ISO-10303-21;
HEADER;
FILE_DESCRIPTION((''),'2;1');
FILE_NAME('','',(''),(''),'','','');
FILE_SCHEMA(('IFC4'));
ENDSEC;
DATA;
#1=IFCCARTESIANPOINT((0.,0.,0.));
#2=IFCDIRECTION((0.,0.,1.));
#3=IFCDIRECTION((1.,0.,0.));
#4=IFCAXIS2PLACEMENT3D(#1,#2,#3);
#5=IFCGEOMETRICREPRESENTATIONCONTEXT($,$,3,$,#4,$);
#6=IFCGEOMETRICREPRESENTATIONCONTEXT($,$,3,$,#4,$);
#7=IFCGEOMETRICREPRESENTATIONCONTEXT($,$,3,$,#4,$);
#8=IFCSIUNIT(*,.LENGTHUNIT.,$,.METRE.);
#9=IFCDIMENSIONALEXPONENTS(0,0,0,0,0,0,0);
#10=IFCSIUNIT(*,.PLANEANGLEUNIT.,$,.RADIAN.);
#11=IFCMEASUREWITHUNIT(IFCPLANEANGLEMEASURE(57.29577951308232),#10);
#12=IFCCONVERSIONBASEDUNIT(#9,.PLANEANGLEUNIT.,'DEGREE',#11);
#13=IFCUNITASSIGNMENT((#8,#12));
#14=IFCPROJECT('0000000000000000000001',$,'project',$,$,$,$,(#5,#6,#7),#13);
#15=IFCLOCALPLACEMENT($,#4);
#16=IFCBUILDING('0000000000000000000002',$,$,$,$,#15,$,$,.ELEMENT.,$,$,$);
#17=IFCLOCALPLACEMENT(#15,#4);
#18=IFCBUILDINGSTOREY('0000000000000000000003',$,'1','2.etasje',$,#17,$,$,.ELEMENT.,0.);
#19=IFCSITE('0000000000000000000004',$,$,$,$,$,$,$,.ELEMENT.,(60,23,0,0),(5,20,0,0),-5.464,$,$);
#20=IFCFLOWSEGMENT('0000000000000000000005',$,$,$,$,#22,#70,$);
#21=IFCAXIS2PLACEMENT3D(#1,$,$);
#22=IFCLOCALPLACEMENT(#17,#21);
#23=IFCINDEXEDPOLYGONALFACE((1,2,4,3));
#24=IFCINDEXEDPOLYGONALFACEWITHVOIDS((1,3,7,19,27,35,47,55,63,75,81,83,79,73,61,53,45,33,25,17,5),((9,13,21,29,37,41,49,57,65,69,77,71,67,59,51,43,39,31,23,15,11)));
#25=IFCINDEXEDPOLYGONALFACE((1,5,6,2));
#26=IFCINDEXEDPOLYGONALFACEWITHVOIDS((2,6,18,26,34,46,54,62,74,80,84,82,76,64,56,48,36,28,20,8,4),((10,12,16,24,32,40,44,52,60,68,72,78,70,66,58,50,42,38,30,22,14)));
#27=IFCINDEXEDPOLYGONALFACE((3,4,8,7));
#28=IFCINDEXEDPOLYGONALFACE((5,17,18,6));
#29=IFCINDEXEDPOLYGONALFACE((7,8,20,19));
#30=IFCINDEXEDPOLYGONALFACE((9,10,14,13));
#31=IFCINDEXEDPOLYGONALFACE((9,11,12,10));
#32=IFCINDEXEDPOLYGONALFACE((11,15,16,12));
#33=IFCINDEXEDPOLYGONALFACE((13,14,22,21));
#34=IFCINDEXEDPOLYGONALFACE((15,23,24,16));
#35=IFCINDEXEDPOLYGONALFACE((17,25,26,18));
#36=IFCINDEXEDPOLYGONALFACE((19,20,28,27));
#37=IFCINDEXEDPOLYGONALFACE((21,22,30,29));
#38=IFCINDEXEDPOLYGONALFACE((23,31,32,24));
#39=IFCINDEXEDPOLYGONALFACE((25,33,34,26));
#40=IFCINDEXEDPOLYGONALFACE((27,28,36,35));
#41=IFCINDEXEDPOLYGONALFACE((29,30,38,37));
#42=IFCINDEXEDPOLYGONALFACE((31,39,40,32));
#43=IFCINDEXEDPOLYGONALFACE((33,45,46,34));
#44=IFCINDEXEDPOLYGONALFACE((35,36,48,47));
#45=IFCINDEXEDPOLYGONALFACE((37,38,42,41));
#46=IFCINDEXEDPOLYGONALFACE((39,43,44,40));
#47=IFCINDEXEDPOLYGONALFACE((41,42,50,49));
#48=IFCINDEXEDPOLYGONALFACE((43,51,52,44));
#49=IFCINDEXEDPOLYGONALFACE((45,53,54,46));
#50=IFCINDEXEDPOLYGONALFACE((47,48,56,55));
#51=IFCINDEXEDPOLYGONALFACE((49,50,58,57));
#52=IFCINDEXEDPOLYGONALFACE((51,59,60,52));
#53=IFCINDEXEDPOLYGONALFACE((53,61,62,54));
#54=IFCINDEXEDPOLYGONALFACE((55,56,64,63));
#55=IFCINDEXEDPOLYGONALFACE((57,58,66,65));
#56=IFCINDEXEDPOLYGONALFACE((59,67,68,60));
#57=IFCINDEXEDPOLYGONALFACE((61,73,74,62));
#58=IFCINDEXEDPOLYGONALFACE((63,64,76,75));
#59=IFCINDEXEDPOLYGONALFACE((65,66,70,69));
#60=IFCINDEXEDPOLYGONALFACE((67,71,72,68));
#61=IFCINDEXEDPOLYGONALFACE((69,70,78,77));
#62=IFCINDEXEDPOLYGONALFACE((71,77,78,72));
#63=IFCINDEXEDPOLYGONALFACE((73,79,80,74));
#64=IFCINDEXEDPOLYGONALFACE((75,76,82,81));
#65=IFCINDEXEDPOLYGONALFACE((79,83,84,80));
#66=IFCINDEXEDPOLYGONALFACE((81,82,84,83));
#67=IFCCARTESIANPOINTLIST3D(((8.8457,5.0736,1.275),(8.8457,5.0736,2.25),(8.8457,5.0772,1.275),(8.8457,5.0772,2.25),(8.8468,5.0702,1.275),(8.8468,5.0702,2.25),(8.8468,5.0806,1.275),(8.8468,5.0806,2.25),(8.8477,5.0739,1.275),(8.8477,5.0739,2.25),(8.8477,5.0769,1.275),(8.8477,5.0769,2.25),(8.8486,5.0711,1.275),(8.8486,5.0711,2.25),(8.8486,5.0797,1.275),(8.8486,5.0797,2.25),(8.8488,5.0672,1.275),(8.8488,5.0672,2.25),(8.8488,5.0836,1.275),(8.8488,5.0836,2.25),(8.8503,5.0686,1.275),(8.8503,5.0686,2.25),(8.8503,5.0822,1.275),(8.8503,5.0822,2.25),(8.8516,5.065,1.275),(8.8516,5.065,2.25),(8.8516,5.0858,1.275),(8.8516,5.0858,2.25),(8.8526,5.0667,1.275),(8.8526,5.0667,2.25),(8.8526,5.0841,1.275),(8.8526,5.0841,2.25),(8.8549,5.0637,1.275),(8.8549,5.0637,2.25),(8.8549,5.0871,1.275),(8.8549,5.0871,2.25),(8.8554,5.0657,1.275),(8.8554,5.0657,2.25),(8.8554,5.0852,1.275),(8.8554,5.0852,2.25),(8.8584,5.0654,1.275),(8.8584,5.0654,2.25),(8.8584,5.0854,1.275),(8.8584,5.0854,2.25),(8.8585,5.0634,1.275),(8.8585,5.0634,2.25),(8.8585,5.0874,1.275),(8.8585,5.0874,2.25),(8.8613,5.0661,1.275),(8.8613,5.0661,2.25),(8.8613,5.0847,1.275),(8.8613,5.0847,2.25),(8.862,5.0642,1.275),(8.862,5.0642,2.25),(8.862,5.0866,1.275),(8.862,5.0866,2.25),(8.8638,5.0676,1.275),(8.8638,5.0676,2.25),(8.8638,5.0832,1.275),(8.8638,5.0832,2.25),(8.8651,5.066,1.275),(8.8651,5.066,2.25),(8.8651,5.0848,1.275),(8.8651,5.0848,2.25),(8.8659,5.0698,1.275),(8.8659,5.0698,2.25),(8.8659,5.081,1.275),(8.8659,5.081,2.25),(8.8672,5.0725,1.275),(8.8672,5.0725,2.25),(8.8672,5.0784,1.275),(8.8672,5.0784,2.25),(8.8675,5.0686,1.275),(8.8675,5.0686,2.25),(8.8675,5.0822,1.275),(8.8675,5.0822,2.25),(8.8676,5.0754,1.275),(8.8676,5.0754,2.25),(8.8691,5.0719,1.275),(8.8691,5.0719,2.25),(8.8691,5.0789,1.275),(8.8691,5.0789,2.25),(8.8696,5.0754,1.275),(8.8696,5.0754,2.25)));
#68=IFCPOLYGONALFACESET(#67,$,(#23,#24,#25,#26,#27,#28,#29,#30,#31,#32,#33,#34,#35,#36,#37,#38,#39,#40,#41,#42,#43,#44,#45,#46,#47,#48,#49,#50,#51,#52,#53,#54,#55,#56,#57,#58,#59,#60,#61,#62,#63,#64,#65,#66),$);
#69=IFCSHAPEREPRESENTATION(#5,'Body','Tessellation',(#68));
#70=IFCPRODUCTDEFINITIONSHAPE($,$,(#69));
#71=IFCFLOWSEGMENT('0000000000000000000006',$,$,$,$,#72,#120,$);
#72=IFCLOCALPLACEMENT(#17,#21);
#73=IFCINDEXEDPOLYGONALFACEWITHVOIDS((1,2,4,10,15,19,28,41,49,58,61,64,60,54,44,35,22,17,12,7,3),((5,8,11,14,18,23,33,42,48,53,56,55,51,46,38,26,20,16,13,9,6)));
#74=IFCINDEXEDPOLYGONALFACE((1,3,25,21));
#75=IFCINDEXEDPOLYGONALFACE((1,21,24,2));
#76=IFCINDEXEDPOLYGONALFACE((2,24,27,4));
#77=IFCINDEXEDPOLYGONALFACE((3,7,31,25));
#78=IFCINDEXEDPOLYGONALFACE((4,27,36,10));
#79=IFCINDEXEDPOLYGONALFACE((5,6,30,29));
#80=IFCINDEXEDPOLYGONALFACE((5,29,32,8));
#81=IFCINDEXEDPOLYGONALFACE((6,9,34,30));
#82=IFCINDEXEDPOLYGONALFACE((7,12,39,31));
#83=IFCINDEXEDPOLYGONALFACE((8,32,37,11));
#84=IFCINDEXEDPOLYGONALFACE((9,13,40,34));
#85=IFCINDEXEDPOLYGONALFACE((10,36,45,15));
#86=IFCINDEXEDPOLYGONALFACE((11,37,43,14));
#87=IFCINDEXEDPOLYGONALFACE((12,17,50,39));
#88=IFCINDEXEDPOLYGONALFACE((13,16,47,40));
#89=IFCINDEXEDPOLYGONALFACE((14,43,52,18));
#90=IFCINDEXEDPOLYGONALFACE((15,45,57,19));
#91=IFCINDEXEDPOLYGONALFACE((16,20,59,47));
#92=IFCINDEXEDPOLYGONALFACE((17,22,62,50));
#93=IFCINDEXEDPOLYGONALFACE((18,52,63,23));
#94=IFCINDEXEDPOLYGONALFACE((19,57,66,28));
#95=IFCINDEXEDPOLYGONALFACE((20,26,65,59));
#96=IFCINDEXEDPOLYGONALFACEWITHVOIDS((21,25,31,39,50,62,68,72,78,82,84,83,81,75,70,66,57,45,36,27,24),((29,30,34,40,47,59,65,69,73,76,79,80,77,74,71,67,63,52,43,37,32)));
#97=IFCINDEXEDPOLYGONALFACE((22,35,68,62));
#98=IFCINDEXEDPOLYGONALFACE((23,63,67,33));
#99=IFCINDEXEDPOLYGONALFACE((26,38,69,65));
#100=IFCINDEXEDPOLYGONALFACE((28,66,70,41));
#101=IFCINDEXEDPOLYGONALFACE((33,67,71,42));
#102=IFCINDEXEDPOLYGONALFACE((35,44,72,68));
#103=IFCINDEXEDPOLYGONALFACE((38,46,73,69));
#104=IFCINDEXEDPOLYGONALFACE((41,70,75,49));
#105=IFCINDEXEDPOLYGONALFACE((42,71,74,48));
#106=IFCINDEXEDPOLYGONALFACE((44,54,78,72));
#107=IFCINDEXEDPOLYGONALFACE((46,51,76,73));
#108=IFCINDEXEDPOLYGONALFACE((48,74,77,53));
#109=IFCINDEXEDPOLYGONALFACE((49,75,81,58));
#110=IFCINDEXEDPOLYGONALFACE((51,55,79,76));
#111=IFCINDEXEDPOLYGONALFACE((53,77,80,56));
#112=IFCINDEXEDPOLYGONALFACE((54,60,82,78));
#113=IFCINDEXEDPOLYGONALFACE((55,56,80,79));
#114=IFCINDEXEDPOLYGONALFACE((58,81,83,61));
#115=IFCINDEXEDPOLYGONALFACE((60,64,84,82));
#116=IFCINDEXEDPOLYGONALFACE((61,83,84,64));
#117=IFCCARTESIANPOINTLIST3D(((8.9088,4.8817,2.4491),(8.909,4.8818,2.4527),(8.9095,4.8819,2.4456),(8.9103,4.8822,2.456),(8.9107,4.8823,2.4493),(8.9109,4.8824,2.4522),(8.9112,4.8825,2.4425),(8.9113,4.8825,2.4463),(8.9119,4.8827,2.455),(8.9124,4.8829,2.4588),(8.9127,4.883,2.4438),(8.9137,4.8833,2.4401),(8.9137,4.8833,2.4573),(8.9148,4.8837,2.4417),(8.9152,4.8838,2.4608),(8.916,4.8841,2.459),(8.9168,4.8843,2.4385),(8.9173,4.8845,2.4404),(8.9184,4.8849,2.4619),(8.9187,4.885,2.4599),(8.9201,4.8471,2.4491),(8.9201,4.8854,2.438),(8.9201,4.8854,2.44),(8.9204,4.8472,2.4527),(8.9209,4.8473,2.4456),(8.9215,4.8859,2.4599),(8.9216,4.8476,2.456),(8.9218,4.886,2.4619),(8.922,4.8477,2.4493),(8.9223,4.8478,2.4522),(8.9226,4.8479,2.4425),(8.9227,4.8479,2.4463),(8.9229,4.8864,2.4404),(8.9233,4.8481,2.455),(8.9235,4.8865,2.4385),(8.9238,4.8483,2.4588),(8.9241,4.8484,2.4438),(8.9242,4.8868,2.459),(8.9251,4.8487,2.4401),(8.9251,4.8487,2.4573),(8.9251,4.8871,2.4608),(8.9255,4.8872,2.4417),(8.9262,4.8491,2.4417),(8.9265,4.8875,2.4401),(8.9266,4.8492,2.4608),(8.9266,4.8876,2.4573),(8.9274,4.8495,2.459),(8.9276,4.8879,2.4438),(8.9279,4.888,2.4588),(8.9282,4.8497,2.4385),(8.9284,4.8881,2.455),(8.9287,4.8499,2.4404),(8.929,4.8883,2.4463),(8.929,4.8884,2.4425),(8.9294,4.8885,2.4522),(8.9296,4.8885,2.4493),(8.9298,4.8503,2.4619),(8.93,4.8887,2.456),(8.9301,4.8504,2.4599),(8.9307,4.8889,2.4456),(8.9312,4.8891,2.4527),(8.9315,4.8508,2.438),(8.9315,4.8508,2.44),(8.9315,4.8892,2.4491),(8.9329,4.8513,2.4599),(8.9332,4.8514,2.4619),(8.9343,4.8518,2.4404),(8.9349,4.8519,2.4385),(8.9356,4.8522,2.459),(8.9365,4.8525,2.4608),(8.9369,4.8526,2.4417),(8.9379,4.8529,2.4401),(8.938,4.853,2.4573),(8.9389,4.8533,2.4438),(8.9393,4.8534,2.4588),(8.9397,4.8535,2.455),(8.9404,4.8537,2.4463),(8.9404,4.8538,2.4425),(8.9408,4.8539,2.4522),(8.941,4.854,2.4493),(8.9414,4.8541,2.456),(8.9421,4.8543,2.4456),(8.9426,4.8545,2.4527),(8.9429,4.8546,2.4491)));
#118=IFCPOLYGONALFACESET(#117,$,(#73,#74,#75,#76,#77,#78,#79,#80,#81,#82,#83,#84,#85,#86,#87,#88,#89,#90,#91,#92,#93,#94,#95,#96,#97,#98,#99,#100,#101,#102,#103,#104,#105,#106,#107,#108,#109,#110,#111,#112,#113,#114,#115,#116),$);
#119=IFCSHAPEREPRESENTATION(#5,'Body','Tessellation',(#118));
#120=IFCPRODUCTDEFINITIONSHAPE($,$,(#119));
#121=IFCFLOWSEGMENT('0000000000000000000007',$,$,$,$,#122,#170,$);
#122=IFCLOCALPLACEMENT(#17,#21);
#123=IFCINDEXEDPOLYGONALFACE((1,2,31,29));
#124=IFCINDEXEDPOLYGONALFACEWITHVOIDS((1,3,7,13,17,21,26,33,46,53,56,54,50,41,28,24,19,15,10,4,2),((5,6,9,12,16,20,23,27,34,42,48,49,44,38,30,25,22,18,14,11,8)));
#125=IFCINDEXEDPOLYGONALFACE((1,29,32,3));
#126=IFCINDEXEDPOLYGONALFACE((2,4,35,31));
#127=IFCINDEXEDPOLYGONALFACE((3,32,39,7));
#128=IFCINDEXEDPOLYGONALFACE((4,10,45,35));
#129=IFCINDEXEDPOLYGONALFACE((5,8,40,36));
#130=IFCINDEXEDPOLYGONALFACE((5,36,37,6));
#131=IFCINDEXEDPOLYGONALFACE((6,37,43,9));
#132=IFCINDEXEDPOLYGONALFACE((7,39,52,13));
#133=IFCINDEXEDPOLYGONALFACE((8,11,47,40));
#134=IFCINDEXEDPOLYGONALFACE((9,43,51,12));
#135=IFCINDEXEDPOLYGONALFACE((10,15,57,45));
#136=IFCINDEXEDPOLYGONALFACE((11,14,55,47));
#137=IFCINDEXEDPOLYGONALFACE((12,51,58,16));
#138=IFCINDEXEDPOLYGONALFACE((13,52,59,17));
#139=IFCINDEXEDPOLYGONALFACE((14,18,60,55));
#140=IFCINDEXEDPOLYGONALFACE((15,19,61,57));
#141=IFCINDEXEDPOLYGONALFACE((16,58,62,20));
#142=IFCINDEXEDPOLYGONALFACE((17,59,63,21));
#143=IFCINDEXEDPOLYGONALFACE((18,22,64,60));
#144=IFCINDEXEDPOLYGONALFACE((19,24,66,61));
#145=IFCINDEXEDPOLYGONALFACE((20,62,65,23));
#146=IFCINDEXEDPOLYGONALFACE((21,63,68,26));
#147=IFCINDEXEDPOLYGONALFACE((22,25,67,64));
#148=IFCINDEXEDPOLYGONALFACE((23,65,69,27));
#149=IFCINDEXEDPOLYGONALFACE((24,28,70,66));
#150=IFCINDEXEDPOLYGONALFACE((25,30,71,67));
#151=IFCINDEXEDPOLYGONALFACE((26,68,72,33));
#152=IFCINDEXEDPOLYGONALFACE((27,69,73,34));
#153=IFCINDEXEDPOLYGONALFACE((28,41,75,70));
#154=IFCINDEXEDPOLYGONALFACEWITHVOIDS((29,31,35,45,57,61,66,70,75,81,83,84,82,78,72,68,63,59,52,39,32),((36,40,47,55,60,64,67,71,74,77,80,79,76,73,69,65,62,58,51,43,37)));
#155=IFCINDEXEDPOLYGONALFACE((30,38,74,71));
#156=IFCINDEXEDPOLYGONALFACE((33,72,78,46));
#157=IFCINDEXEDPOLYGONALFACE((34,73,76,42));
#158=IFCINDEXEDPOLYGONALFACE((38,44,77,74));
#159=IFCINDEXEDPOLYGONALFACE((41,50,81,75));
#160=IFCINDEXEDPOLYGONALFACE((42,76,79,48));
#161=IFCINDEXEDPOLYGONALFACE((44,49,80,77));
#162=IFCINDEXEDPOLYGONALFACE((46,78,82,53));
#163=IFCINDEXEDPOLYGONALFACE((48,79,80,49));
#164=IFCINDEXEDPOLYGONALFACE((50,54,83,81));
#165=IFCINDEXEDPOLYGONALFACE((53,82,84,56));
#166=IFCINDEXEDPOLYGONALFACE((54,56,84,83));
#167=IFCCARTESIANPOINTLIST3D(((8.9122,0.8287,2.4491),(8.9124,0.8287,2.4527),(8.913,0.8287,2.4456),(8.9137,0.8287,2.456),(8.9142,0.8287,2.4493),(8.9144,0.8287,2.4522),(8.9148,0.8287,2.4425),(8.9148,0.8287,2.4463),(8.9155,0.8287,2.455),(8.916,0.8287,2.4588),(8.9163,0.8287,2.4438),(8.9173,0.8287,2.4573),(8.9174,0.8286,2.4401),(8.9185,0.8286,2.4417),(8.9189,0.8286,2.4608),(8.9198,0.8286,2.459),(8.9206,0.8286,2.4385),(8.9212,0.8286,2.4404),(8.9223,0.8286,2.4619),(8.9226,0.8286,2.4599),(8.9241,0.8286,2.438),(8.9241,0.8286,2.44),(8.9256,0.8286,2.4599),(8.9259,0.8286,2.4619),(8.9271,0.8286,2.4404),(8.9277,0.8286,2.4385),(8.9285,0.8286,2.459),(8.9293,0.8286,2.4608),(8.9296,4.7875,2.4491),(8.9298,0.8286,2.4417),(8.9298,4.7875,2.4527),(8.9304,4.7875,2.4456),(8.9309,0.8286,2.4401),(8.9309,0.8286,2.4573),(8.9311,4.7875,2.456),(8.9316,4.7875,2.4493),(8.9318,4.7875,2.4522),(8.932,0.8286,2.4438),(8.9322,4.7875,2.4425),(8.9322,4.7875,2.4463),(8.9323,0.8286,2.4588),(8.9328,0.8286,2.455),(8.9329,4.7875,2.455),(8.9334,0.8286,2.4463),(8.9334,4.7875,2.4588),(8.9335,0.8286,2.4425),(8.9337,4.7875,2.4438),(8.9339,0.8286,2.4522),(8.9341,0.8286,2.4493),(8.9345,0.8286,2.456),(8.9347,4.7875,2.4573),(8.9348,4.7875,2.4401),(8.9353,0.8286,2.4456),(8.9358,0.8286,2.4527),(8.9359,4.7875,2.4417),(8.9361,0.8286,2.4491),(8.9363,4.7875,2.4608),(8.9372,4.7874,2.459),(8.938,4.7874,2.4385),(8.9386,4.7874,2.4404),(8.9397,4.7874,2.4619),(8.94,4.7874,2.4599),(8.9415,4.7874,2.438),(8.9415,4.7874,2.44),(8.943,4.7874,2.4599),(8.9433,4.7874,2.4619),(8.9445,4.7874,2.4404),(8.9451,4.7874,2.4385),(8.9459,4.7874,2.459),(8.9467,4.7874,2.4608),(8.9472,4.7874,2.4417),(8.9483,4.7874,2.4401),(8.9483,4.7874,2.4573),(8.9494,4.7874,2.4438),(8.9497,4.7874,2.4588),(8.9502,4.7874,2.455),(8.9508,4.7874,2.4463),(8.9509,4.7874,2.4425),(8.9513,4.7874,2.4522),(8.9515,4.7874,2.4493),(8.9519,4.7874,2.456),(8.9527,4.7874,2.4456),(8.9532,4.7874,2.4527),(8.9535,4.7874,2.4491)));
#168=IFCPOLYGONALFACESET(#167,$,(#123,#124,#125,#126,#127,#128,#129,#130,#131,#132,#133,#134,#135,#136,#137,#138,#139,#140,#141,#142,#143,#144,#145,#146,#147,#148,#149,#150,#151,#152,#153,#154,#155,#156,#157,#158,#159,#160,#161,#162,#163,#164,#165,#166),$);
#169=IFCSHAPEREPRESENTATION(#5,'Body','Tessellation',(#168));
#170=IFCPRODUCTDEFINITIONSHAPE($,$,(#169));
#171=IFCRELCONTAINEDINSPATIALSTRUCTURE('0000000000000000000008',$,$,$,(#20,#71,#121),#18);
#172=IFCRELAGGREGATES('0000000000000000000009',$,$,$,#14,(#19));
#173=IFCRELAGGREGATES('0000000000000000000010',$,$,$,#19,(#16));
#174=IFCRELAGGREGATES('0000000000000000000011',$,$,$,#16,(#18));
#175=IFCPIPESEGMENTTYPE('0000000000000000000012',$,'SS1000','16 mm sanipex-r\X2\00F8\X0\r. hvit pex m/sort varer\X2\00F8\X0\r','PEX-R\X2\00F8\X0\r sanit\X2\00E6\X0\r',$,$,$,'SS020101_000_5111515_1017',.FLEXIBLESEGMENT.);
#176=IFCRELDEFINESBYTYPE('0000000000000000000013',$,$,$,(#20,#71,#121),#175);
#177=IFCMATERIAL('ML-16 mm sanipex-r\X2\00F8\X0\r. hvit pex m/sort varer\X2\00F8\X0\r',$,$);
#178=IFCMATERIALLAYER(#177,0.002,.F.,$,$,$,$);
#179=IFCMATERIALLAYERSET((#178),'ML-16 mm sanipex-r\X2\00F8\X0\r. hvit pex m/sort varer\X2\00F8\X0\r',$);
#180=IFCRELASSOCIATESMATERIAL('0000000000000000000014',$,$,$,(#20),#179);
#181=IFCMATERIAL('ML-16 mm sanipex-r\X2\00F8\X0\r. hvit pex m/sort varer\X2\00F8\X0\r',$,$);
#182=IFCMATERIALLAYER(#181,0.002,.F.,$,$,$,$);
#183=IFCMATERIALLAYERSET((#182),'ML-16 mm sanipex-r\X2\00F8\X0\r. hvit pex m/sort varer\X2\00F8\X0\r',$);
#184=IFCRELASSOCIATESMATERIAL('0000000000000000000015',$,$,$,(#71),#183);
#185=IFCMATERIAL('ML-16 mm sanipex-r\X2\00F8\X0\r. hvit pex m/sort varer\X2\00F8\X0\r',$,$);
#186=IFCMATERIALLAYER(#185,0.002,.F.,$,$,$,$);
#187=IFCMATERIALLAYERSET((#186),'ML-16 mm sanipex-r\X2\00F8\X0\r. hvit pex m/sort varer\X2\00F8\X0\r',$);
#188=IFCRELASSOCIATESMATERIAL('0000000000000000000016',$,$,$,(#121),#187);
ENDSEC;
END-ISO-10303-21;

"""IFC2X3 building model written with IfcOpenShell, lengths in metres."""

from ifc_helpers import new_model, entity, si_unit, converted_unit, frame, origin_with_axes, origin_2d_with_axis, place, context, project, spatial, hollow_circle, extrude, material, layer, layer_set, layer_usage, type_object, element, save


model = new_model("IFC2X3")

# Units and contexts
context_of_model_1 = context(None, 3, world=origin_with_axes())
context_of_model_2 = context(None, 3, world=origin_with_axes())
context_of_model_3 = context(None, 3, world=origin_with_axes())
ifc_project = project(units=[si_unit("LENGTHUNIT", "METRE"), converted_unit("PLANEANGLEUNIT", "DEGREE", entity("IfcPlaneAngleMeasure", 57.29577951308232), si_unit("PLANEANGLEUNIT", "RADIAN"), dimensions=[0, 0, 0, 0, 0, 0, 0])], contexts=[context_of_model_1, context_of_model_2, context_of_model_3])

# Site, building, storey
site = spatial("IfcSite", under=ifc_project, CompositionType="ELEMENT", RefLatitude=(60, 23, 0, 0), RefLongitude=(5, 20, 0, 0), RefElevation=-5.464)
building_placement = place(None, origin_with_axes())
building = spatial("IfcBuilding", under=site, at=building_placement, CompositionType="ELEMENT")
storey_placement = place(building_placement, origin_with_axes())
storey = spatial("IfcBuildingStorey", under=building, at=storey_placement, Name="1", Description="2.etasje", CompositionType="ELEMENT", Elevation=0.0)

# Flow segments
ifc_material_1 = material(Name="ML-16 mm sanipex-rør. hvit pex m/sort varerør")
ifc_layer_1 = layer(ifc_material_1, 0.002, ventilated=False)
ifc_layer_set_1 = layer_set([ifc_layer_1], Name="ML-16 mm sanipex-rør. hvit pex m/sort varerør")
ifc_layer_usage_1 = layer_usage(ifc_layer_set_1, "AXIS2", "POSITIVE", 0.0)
pipe_segment_type_1 = type_object("IfcPipeSegmentType", Name="SS1000", Description="16 mm sanipex-rør. hvit pex m/sort varerør", ApplicableOccurrence="PEX-Rør sanitær", ElementType="SS020101_000_5111515_1017", PredefinedType="FLEXIBLESEGMENT")
flow_segment_1_placement = place(storey_placement, frame((8.8576, 5.0754, 1.275), z_axis=(0.0, 0.0, 1.0), x_axis=(1.0, 0.0, 0.0)))
element("IfcFlowSegment", 1, at=flow_segment_1_placement, inside=storey, type_object=pipe_segment_type_1, material=ifc_layer_usage_1, context=context_of_model_1, shape_type="SweptSolid", body=[
    extrude(hollow_circle(Radius=0.012, WallThickness=0.002, at=origin_2d_with_axis()), origin_with_axes(), (0.0, 0.0, 1.0), 0.975),
])
ifc_material_2 = material(Name="ML-16 mm sanipex-rør. hvit pex m/sort varerør")
ifc_layer_2 = layer(ifc_material_2, 0.002, ventilated=False)
ifc_layer_set_2 = layer_set([ifc_layer_2], Name="ML-16 mm sanipex-rør. hvit pex m/sort varerør")
ifc_layer_usage_2 = layer_usage(ifc_layer_set_2, "AXIS2", "POSITIVE", 0.0)
flow_segment_2_placement = place(storey_placement, frame((8.9201, 4.8854, 2.45), z_axis=(0.312628, -0.949875, 0.0), x_axis=(0.0, 0.0, -1.0)))
element("IfcFlowSegment", 2, at=flow_segment_2_placement, inside=storey, type_object=pipe_segment_type_1, material=ifc_layer_usage_2, context=context_of_model_1, shape_type="SweptSolid", body=[
    extrude(hollow_circle(Radius=0.012, WallThickness=0.002, at=origin_2d_with_axis()), origin_with_axes(), (0.0, 0.0, 1.0), 0.0364),
])
ifc_material_3 = material(Name="ML-16 mm sanipex-rør. hvit pex m/sort varerør")
ifc_layer_3 = layer(ifc_material_3, 0.002, ventilated=False)
ifc_layer_set_3 = layer_set([ifc_layer_3], Name="ML-16 mm sanipex-rør. hvit pex m/sort varerør")
ifc_layer_usage_3 = layer_usage(ifc_layer_set_3, "AXIS2", "POSITIVE", 0.0)
flow_segment_3_placement = place(storey_placement, frame((8.9415, 4.7874, 2.45), z_axis=(-0.004396, -0.99999, 0.0), x_axis=(0.0, 0.0, -1.0)))
element("IfcFlowSegment", 3, at=flow_segment_3_placement, inside=storey, type_object=pipe_segment_type_1, material=ifc_layer_usage_3, context=context_of_model_1, shape_type="SweptSolid", body=[
    extrude(hollow_circle(Radius=0.012, WallThickness=0.002, at=origin_2d_with_axis()), origin_with_axes(), (0.0, 0.0, 1.0), 3.9588),
])

save(model, "model.ifc")
